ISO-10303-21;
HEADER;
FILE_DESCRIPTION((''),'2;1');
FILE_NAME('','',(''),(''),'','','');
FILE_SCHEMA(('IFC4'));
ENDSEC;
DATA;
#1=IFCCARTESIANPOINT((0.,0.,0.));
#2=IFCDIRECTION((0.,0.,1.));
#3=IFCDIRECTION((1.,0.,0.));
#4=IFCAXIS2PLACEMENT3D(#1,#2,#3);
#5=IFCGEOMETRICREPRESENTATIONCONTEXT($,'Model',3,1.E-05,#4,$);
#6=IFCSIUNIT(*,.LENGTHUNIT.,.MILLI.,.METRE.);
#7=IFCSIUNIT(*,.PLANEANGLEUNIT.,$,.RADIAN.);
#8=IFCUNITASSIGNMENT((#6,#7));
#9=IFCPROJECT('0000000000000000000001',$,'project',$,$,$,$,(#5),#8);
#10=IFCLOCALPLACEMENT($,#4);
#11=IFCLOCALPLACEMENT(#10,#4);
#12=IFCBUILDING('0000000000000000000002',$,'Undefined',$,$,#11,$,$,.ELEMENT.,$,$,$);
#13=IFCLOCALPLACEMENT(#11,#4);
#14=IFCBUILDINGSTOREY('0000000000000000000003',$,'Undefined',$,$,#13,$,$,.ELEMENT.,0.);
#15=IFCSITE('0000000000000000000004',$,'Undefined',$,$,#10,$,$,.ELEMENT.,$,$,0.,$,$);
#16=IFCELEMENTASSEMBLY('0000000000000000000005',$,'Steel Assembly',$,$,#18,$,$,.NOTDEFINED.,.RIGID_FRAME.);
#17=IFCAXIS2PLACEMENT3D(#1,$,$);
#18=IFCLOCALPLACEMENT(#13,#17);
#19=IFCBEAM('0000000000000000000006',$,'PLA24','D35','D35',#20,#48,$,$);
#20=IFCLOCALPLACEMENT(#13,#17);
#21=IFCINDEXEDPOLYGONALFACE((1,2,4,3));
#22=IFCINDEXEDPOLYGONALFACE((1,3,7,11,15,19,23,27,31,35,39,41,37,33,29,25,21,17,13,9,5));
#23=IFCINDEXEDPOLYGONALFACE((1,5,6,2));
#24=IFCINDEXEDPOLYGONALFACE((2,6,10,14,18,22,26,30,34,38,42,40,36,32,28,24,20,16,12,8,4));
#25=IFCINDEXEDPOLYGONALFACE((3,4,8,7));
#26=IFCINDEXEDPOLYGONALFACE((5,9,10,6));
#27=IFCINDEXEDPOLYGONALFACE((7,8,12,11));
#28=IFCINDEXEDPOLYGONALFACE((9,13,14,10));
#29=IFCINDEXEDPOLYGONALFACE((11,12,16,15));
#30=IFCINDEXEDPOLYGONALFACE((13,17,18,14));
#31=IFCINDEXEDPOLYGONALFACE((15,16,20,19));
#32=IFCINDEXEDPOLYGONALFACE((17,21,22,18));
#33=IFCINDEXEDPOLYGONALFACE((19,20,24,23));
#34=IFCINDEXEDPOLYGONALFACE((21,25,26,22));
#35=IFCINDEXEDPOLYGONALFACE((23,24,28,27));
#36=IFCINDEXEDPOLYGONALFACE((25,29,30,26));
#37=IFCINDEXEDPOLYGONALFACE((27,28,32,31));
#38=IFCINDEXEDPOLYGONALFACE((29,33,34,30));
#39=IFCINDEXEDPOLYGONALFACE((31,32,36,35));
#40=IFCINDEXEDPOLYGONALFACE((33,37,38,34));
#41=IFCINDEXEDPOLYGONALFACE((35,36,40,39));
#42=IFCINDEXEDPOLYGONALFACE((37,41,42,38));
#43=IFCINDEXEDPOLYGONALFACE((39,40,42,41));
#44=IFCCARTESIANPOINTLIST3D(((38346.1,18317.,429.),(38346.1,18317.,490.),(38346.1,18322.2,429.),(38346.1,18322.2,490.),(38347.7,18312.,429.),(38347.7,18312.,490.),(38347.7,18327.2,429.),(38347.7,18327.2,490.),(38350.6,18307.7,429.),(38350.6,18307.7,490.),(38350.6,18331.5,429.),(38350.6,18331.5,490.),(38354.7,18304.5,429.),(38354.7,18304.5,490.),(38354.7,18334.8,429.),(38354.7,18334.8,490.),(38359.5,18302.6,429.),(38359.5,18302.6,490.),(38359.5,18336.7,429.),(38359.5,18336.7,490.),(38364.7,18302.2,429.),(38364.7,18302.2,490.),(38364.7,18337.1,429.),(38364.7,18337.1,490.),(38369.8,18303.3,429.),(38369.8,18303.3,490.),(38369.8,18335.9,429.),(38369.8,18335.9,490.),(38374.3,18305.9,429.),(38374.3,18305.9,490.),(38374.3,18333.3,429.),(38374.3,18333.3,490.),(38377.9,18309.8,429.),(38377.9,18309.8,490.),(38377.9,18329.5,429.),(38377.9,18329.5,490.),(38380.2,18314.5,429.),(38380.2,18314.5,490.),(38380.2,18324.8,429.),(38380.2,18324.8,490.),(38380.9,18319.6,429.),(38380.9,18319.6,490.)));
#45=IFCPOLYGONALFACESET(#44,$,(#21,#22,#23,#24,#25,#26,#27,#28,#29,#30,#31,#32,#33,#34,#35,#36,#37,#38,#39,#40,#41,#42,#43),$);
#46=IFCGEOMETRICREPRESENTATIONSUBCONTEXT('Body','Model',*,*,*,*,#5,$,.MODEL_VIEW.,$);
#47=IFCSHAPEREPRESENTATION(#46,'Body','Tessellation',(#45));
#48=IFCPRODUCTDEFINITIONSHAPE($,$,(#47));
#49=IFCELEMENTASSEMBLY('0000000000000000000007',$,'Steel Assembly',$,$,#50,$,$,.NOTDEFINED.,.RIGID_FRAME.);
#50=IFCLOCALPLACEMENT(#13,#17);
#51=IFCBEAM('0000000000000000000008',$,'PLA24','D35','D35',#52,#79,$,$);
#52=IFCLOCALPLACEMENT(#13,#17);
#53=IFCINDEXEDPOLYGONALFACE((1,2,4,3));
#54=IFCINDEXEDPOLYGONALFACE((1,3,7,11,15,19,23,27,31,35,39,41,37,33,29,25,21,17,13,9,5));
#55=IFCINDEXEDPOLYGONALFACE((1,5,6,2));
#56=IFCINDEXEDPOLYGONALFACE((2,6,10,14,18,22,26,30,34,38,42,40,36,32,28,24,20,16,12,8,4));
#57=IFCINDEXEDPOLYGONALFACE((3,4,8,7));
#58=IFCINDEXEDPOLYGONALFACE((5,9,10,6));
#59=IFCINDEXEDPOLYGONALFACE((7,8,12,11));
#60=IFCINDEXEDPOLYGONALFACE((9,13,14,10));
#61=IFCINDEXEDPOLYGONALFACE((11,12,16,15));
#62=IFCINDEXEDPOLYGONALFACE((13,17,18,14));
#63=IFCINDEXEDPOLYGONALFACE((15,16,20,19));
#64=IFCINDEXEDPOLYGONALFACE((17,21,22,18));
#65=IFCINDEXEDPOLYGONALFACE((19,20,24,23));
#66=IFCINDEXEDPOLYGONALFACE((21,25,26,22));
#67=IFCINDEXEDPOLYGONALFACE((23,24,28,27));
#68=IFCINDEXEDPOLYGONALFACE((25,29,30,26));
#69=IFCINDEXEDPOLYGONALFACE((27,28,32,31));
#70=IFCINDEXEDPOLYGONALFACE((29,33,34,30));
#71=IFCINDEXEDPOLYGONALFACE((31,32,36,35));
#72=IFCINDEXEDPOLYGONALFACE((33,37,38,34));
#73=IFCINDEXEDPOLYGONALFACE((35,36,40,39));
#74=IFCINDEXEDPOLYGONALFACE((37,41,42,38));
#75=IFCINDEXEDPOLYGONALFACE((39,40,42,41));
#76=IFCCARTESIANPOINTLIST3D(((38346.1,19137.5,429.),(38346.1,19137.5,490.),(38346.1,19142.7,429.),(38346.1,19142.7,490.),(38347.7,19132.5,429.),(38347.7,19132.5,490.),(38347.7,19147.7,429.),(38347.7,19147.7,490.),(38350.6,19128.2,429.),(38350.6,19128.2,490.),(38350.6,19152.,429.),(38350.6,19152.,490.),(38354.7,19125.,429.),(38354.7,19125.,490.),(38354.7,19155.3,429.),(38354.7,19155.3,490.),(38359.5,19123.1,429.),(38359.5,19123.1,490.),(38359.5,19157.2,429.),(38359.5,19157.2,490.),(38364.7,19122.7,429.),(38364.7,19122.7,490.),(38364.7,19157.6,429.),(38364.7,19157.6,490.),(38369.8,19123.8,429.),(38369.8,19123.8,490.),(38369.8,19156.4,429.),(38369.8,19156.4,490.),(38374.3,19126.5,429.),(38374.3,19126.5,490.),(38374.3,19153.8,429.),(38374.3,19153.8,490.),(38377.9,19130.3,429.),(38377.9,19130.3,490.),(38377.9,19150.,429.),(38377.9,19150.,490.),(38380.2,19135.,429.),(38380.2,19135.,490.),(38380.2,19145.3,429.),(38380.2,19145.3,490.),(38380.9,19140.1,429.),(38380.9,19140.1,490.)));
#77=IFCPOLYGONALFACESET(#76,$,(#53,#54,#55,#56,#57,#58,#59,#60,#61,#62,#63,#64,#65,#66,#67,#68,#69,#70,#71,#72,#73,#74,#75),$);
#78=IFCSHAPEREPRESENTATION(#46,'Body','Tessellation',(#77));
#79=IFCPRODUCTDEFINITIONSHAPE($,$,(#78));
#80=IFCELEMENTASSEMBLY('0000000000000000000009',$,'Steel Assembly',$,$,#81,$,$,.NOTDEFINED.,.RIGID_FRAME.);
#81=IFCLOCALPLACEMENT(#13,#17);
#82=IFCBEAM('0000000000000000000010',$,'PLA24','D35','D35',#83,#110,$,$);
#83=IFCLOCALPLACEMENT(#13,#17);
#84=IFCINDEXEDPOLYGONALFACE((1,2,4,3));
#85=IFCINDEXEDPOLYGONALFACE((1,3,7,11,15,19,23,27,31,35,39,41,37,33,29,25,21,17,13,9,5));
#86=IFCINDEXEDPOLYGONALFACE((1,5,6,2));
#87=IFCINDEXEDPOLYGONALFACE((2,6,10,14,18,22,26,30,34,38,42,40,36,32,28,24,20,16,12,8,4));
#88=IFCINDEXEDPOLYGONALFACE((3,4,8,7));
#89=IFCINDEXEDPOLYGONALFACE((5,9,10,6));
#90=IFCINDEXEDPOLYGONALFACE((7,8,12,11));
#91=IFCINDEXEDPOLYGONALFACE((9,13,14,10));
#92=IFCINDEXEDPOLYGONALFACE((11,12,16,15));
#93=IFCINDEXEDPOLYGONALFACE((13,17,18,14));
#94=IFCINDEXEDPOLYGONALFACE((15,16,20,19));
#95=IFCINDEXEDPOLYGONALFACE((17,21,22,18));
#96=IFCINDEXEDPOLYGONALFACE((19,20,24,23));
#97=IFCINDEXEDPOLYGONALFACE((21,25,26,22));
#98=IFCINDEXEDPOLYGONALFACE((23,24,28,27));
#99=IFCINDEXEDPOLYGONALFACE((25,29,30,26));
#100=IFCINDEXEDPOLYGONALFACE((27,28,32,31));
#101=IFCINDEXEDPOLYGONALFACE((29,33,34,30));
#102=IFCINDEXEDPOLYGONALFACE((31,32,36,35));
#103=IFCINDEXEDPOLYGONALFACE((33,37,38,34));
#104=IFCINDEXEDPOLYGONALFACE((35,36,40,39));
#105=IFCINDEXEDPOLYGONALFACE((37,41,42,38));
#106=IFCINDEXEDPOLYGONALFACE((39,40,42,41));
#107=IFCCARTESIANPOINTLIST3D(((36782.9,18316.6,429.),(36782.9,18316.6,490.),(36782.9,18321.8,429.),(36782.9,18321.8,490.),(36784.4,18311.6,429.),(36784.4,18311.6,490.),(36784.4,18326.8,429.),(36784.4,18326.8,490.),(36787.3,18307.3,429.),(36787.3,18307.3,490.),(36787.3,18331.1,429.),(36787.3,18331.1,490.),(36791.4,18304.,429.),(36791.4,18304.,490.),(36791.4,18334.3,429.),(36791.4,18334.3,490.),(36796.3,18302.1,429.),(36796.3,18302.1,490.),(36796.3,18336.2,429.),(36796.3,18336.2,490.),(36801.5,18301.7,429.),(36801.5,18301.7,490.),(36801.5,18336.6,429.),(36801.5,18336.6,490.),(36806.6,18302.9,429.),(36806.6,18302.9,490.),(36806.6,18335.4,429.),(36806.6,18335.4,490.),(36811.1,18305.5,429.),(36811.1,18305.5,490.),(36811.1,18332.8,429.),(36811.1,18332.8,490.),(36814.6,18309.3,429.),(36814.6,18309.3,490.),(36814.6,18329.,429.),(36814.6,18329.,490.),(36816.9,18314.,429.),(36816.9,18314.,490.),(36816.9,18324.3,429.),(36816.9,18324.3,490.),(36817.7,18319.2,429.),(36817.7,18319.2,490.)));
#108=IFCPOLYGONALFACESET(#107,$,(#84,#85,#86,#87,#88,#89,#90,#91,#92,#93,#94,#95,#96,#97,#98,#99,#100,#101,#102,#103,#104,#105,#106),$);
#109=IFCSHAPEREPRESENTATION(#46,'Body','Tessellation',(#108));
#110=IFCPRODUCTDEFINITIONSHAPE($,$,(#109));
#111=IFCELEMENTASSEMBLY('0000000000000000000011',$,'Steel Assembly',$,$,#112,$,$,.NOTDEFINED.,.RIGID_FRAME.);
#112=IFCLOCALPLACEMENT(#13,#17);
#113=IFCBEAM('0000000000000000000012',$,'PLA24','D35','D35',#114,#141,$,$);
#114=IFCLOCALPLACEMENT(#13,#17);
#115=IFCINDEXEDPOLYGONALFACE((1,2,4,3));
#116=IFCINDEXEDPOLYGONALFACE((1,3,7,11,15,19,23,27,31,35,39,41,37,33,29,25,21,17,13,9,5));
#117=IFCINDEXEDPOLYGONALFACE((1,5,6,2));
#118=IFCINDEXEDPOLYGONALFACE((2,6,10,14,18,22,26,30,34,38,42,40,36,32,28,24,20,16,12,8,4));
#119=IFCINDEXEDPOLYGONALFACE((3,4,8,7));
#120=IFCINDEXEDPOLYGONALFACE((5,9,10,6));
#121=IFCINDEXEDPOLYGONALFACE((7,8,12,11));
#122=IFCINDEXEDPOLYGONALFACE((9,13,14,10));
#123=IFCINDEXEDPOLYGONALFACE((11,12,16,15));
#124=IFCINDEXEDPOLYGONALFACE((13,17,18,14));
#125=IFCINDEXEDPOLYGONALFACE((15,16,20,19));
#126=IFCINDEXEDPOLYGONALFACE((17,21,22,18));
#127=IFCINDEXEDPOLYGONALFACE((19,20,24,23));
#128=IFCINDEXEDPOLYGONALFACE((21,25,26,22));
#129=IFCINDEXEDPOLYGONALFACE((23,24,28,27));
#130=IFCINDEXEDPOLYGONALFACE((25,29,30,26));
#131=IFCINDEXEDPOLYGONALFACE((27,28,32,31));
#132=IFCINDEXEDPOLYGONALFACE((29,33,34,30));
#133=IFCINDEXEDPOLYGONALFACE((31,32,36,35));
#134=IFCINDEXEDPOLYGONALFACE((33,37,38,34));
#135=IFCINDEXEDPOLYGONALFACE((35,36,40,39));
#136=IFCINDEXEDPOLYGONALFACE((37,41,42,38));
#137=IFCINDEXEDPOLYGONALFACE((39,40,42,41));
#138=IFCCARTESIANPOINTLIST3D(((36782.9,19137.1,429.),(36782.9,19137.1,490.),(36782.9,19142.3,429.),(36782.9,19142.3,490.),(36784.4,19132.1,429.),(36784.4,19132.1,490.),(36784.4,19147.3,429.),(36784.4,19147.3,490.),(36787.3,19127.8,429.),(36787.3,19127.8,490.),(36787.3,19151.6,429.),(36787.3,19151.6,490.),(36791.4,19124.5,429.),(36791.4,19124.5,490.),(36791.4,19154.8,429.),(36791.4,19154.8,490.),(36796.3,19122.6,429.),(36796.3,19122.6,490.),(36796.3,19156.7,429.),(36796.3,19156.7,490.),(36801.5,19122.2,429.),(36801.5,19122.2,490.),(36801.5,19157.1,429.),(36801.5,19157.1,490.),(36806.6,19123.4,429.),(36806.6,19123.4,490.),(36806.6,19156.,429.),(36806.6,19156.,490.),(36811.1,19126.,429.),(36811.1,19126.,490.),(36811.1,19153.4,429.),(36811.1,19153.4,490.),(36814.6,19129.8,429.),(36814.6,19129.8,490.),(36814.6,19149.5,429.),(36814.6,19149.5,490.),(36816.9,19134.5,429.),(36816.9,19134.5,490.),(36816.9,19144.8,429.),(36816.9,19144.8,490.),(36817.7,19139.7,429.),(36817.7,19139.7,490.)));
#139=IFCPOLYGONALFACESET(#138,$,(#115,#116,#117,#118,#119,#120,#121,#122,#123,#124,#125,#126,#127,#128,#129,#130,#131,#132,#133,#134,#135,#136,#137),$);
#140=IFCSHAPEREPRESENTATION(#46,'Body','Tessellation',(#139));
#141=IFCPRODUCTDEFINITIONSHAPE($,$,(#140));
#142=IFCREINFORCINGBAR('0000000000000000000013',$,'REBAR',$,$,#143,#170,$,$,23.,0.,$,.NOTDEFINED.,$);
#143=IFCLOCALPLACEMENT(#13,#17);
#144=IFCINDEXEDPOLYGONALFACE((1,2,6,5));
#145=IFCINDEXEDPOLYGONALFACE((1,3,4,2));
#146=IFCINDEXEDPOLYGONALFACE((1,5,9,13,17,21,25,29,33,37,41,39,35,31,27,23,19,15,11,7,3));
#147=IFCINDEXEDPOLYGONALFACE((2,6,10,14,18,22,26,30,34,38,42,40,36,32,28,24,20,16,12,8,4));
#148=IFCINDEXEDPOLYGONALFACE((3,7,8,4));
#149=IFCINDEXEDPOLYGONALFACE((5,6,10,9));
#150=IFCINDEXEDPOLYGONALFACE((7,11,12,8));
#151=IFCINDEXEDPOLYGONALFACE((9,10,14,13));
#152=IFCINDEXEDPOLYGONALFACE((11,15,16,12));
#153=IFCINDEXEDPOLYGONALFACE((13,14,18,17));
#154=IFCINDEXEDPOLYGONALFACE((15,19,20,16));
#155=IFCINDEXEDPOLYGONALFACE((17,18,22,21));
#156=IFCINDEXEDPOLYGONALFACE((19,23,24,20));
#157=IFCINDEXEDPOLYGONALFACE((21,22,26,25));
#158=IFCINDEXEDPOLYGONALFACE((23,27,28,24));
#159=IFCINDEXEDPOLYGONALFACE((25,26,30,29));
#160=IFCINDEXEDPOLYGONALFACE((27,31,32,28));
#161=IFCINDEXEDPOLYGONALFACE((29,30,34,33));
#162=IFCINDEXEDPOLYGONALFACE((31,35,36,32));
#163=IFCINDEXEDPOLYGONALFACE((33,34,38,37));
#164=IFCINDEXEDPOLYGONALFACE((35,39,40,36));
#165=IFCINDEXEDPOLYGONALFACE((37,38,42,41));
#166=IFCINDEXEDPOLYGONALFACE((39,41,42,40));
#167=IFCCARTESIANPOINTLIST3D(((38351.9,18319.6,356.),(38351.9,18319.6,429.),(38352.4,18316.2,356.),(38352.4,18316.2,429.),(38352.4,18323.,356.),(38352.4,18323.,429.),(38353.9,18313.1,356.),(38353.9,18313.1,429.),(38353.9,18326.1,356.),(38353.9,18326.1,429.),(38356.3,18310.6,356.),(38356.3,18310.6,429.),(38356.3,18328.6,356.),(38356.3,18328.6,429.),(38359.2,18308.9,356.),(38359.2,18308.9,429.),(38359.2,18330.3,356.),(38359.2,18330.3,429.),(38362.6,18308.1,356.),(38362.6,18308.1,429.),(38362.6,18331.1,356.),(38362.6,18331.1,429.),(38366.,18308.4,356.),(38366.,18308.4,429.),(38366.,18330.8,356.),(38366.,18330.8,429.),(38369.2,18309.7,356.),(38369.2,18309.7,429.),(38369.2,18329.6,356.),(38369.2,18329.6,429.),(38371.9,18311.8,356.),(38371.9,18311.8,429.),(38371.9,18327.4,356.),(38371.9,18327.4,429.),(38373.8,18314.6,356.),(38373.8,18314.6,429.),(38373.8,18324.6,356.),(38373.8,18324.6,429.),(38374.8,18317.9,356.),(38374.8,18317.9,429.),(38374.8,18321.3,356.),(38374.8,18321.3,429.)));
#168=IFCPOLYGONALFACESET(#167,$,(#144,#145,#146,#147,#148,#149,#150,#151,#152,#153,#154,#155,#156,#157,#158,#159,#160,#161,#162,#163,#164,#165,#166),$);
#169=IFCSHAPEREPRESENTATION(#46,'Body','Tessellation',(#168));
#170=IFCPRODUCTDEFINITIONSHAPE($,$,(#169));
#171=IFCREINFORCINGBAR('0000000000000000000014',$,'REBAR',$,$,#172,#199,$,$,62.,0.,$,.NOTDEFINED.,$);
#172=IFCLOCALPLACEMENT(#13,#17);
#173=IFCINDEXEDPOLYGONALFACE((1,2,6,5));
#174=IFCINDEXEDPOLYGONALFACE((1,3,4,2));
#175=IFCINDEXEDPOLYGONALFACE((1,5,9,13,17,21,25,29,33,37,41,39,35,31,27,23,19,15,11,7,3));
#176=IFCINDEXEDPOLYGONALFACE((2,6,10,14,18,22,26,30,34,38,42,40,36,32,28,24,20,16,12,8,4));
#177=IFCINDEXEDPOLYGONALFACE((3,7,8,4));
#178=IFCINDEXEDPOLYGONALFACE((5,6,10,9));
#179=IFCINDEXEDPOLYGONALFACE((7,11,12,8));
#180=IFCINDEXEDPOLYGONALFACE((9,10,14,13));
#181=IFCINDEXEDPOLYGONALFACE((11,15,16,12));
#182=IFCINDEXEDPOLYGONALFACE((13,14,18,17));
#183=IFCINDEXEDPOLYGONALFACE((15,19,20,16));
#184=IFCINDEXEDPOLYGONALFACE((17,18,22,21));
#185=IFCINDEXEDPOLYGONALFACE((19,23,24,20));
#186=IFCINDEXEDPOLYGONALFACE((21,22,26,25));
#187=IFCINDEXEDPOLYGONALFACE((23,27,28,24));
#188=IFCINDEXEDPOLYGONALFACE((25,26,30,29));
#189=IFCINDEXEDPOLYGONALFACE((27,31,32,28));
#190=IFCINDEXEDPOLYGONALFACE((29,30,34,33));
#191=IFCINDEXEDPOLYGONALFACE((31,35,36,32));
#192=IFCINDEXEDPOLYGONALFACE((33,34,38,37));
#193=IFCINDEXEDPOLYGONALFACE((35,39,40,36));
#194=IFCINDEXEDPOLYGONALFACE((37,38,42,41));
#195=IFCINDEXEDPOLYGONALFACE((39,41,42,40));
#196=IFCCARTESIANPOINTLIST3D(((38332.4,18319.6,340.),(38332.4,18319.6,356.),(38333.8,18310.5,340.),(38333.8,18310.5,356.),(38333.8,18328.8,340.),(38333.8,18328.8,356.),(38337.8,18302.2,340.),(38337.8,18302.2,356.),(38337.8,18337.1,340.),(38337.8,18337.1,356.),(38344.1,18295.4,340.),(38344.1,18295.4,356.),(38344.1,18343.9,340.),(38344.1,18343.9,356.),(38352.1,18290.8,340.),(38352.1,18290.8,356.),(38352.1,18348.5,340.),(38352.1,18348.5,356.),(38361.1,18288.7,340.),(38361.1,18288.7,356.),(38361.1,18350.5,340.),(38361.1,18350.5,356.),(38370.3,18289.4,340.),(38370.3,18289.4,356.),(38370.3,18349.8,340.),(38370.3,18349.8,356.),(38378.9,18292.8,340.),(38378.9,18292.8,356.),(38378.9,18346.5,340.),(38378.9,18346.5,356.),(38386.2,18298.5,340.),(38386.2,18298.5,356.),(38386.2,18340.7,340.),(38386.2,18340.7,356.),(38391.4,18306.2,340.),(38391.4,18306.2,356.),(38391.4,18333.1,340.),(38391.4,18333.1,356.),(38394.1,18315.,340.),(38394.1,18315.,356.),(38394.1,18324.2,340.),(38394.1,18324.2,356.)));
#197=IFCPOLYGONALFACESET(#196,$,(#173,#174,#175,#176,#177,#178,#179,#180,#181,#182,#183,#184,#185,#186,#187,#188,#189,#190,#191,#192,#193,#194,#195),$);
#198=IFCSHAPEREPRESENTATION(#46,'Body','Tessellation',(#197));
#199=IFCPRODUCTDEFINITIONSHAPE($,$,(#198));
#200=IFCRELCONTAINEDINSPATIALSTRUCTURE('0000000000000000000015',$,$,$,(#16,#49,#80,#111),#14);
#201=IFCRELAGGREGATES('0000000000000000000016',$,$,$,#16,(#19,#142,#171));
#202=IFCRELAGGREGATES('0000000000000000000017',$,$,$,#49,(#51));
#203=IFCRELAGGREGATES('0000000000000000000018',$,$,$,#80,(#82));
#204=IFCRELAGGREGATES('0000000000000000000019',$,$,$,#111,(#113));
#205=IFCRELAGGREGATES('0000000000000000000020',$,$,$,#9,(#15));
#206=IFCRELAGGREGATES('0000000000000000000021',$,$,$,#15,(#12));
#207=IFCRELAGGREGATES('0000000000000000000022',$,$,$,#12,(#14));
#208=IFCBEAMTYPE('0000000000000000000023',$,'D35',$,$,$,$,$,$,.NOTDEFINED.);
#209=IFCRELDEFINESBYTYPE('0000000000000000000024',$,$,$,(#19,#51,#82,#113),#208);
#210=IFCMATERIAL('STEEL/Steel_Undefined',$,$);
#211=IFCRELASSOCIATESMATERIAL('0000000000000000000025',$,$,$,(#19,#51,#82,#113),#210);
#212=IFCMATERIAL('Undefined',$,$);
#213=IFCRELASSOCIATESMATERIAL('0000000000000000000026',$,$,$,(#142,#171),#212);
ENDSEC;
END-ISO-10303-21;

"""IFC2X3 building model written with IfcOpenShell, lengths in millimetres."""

from ifc_helpers import new_model, entity, si_unit, frame, origin_with_axes, origin_2d_with_axis, place, context, subcontext, project, spatial, circle, extrude, source, transform, mapped, material, type_object, element, aggregate, save


model = new_model("IFC2X3")

# Units and contexts
model_context = context("Model", 3, precision=1e-05, world=origin_with_axes())
body_context = subcontext(model_context, "Body", "Model", "MODEL_VIEW")
ifc_project = project(units=[si_unit("LENGTHUNIT", "METRE", prefix="MILLI"), si_unit("PLANEANGLEUNIT", "RADIAN")], contexts=[model_context])

# Site, building, storey
site_placement = place(None, origin_with_axes())
site = spatial("IfcSite", under=ifc_project, at=site_placement, Name="Undefined", CompositionType="ELEMENT", RefElevation=0.0)
building_placement = place(site_placement, origin_with_axes())
building = spatial("IfcBuilding", under=site, at=building_placement, Name="Undefined", CompositionType="ELEMENT")
storey_placement = place(building_placement, origin_with_axes())
storey = spatial("IfcBuildingStorey", under=building, at=storey_placement, Name="Undefined", CompositionType="ELEMENT", Elevation=0.0)

# Element assemblies, beams
assembly_1_placement = place(storey_placement, origin_with_axes())
assembly_1 = element("IfcElementAssembly", 1, at=assembly_1_placement, inside=storey, Name="Steel Assembly", AssemblyPlace="NOTDEFINED", PredefinedType="RIGID_FRAME")
ifc_material_1 = material(Name="STEEL/Steel_Undefined")
beam_type = type_object("IfcBeamType", Name="D35", PredefinedType="NOTDEFINED")
beam_1_placement = place(assembly_1_placement, frame((38363.4, 18319.6, 490.0), z_axis=(0.000005, 1.0, 0.0), x_axis=(0.0, 0.0, -1.0)))
beam_1 = element("IfcBeam", 2, at=beam_1_placement, type_object=beam_type, material=ifc_material_1, Name="PLA24", Description="D35", ObjectType="D35", context=body_context, shape_type="SweptSolid", body=[
    extrude(circle(Radius=17.5, at=origin_2d_with_axis()), frame((61.0, 0.0, 0.0), z_axis=(-1.0, 0.0, 0.0), x_axis=(0.0, -1.0, 0.0)), (0.0, 0.0, 1.0), 61.0),
])
assembly_2_placement = place(storey_placement, origin_with_axes())
assembly_2 = element("IfcElementAssembly", 3, at=assembly_2_placement, inside=storey, Name="Steel Assembly", AssemblyPlace="NOTDEFINED", PredefinedType="RIGID_FRAME")
beam_2_placement = place(assembly_2_placement, frame((38363.4, 19140.1, 490.0), z_axis=(0.000005, 1.0, 0.0), x_axis=(0.0, 0.0, -1.0)))
beam_2 = element("IfcBeam", 4, at=beam_2_placement, type_object=beam_type, material=ifc_material_1, Name="PLA24", Description="D35", ObjectType="D35", context=body_context, shape_type="SweptSolid", body=[
    extrude(circle(Radius=17.5, at=origin_2d_with_axis()), frame((61.0, 0.0, 0.0), z_axis=(-1.0, 0.0, 0.0), x_axis=(0.0, -1.0, 0.0)), (0.0, 0.0, 1.0), 61.0),
])
assembly_3_placement = place(storey_placement, origin_with_axes())
assembly_3 = element("IfcElementAssembly", 5, at=assembly_3_placement, inside=storey, Name="Steel Assembly", AssemblyPlace="NOTDEFINED", PredefinedType="RIGID_FRAME")
beam_3_placement = place(assembly_3_placement, frame((36800.2, 18319.2, 490.0), z_axis=(0.000005, 1.0, 0.0), x_axis=(0.0, 0.0, -1.0)))
beam_3 = element("IfcBeam", 6, at=beam_3_placement, type_object=beam_type, material=ifc_material_1, Name="PLA24", Description="D35", ObjectType="D35", context=body_context, shape_type="SweptSolid", body=[
    extrude(circle(Radius=17.5, at=origin_2d_with_axis()), frame((61.0, 0.0, 0.0), z_axis=(-1.0, 0.0, 0.0), x_axis=(0.0, -1.0, 0.0)), (0.0, 0.0, 1.0), 61.0),
])
assembly_4_placement = place(storey_placement, origin_with_axes())
assembly_4 = element("IfcElementAssembly", 7, at=assembly_4_placement, inside=storey, Name="Steel Assembly", AssemblyPlace="NOTDEFINED", PredefinedType="RIGID_FRAME")
beam_4_placement = place(assembly_4_placement, frame((36800.2, 19139.7, 490.0), z_axis=(0.000005, 1.0, 0.0), x_axis=(0.0, 0.0, -1.0)))
beam_4 = element("IfcBeam", 8, at=beam_4_placement, type_object=beam_type, material=ifc_material_1, Name="PLA24", Description="D35", ObjectType="D35", context=body_context, shape_type="SweptSolid", body=[
    extrude(circle(Radius=17.5, at=origin_2d_with_axis()), frame((61.0, 0.0, 0.0), z_axis=(-1.0, 0.0, 0.0), x_axis=(0.0, -1.0, 0.0)), (0.0, 0.0, 1.0), 61.0),
])

# Reinforcing bars
ifc_material_2 = material(Name="Undefined")
shared_shape_1 = source(origin_with_axes(), body_context, "Body", "AdvancedSweptSolid", [
    entity("IfcSweptDiskSolid", entity("IfcTrimmedCurve", entity("IfcLine", entity("IfcCartesianPoint", [0.0, 0.0, 0.0]), entity("IfcVector", entity("IfcDirection", [1.0, 0.0, 0.0]), 1.0)), [entity("IfcParameterValue", 0.0)], [entity("IfcParameterValue", 73.0)], True, "PARAMETER"), 11.5, None, 0.0, 73.0),
])
reinforcing_bar_1_placement = place(assembly_1_placement, frame((38363.4, 18319.6, 429.0), z_axis=(-1.0, 0.000005, 0.0), x_axis=(0.0, 0.0, -1.0)))
reinforcing_bar_1 = element("IfcReinforcingBar", 9, at=reinforcing_bar_1_placement, material=ifc_material_2, Name="REBAR", BarRole="NOTDEFINED", CrossSectionArea=0.0, NominalDiameter=23.0, context=body_context, shape_type="MappedRepresentation", body=[
    mapped(shared_shape_1, transform((0.0, 0.0, 0.0))),
])
shared_shape_2 = source(origin_with_axes(), body_context, "Body", "AdvancedSweptSolid", [
    entity("IfcSweptDiskSolid", entity("IfcTrimmedCurve", entity("IfcLine", entity("IfcCartesianPoint", [0.0, 0.0, 0.0]), entity("IfcVector", entity("IfcDirection", [1.0, 0.0, 0.0]), 1.0)), [entity("IfcParameterValue", 0.0)], [entity("IfcParameterValue", 16.0)], True, "PARAMETER"), 31.0, None, 0.0, 16.0),
])
reinforcing_bar_2_placement = place(assembly_1_placement, frame((38363.4, 18319.6, 353.0), z_axis=(-1.0, 0.000005, 0.0), x_axis=(0.0, 0.0, -1.0)))
reinforcing_bar_2 = element("IfcReinforcingBar", 10, at=reinforcing_bar_2_placement, material=ifc_material_2, Name="REBAR", BarRole="NOTDEFINED", CrossSectionArea=0.0, NominalDiameter=62.0, context=body_context, shape_type="MappedRepresentation", body=[
    mapped(shared_shape_2, transform((-3.0, 0.0, 0.0))),
])
aggregate(assembly_1, [beam_1, reinforcing_bar_1, reinforcing_bar_2])
aggregate(assembly_2, [beam_2])
aggregate(assembly_3, [beam_3])
aggregate(assembly_4, [beam_4])

save(model, "model.ifc")
